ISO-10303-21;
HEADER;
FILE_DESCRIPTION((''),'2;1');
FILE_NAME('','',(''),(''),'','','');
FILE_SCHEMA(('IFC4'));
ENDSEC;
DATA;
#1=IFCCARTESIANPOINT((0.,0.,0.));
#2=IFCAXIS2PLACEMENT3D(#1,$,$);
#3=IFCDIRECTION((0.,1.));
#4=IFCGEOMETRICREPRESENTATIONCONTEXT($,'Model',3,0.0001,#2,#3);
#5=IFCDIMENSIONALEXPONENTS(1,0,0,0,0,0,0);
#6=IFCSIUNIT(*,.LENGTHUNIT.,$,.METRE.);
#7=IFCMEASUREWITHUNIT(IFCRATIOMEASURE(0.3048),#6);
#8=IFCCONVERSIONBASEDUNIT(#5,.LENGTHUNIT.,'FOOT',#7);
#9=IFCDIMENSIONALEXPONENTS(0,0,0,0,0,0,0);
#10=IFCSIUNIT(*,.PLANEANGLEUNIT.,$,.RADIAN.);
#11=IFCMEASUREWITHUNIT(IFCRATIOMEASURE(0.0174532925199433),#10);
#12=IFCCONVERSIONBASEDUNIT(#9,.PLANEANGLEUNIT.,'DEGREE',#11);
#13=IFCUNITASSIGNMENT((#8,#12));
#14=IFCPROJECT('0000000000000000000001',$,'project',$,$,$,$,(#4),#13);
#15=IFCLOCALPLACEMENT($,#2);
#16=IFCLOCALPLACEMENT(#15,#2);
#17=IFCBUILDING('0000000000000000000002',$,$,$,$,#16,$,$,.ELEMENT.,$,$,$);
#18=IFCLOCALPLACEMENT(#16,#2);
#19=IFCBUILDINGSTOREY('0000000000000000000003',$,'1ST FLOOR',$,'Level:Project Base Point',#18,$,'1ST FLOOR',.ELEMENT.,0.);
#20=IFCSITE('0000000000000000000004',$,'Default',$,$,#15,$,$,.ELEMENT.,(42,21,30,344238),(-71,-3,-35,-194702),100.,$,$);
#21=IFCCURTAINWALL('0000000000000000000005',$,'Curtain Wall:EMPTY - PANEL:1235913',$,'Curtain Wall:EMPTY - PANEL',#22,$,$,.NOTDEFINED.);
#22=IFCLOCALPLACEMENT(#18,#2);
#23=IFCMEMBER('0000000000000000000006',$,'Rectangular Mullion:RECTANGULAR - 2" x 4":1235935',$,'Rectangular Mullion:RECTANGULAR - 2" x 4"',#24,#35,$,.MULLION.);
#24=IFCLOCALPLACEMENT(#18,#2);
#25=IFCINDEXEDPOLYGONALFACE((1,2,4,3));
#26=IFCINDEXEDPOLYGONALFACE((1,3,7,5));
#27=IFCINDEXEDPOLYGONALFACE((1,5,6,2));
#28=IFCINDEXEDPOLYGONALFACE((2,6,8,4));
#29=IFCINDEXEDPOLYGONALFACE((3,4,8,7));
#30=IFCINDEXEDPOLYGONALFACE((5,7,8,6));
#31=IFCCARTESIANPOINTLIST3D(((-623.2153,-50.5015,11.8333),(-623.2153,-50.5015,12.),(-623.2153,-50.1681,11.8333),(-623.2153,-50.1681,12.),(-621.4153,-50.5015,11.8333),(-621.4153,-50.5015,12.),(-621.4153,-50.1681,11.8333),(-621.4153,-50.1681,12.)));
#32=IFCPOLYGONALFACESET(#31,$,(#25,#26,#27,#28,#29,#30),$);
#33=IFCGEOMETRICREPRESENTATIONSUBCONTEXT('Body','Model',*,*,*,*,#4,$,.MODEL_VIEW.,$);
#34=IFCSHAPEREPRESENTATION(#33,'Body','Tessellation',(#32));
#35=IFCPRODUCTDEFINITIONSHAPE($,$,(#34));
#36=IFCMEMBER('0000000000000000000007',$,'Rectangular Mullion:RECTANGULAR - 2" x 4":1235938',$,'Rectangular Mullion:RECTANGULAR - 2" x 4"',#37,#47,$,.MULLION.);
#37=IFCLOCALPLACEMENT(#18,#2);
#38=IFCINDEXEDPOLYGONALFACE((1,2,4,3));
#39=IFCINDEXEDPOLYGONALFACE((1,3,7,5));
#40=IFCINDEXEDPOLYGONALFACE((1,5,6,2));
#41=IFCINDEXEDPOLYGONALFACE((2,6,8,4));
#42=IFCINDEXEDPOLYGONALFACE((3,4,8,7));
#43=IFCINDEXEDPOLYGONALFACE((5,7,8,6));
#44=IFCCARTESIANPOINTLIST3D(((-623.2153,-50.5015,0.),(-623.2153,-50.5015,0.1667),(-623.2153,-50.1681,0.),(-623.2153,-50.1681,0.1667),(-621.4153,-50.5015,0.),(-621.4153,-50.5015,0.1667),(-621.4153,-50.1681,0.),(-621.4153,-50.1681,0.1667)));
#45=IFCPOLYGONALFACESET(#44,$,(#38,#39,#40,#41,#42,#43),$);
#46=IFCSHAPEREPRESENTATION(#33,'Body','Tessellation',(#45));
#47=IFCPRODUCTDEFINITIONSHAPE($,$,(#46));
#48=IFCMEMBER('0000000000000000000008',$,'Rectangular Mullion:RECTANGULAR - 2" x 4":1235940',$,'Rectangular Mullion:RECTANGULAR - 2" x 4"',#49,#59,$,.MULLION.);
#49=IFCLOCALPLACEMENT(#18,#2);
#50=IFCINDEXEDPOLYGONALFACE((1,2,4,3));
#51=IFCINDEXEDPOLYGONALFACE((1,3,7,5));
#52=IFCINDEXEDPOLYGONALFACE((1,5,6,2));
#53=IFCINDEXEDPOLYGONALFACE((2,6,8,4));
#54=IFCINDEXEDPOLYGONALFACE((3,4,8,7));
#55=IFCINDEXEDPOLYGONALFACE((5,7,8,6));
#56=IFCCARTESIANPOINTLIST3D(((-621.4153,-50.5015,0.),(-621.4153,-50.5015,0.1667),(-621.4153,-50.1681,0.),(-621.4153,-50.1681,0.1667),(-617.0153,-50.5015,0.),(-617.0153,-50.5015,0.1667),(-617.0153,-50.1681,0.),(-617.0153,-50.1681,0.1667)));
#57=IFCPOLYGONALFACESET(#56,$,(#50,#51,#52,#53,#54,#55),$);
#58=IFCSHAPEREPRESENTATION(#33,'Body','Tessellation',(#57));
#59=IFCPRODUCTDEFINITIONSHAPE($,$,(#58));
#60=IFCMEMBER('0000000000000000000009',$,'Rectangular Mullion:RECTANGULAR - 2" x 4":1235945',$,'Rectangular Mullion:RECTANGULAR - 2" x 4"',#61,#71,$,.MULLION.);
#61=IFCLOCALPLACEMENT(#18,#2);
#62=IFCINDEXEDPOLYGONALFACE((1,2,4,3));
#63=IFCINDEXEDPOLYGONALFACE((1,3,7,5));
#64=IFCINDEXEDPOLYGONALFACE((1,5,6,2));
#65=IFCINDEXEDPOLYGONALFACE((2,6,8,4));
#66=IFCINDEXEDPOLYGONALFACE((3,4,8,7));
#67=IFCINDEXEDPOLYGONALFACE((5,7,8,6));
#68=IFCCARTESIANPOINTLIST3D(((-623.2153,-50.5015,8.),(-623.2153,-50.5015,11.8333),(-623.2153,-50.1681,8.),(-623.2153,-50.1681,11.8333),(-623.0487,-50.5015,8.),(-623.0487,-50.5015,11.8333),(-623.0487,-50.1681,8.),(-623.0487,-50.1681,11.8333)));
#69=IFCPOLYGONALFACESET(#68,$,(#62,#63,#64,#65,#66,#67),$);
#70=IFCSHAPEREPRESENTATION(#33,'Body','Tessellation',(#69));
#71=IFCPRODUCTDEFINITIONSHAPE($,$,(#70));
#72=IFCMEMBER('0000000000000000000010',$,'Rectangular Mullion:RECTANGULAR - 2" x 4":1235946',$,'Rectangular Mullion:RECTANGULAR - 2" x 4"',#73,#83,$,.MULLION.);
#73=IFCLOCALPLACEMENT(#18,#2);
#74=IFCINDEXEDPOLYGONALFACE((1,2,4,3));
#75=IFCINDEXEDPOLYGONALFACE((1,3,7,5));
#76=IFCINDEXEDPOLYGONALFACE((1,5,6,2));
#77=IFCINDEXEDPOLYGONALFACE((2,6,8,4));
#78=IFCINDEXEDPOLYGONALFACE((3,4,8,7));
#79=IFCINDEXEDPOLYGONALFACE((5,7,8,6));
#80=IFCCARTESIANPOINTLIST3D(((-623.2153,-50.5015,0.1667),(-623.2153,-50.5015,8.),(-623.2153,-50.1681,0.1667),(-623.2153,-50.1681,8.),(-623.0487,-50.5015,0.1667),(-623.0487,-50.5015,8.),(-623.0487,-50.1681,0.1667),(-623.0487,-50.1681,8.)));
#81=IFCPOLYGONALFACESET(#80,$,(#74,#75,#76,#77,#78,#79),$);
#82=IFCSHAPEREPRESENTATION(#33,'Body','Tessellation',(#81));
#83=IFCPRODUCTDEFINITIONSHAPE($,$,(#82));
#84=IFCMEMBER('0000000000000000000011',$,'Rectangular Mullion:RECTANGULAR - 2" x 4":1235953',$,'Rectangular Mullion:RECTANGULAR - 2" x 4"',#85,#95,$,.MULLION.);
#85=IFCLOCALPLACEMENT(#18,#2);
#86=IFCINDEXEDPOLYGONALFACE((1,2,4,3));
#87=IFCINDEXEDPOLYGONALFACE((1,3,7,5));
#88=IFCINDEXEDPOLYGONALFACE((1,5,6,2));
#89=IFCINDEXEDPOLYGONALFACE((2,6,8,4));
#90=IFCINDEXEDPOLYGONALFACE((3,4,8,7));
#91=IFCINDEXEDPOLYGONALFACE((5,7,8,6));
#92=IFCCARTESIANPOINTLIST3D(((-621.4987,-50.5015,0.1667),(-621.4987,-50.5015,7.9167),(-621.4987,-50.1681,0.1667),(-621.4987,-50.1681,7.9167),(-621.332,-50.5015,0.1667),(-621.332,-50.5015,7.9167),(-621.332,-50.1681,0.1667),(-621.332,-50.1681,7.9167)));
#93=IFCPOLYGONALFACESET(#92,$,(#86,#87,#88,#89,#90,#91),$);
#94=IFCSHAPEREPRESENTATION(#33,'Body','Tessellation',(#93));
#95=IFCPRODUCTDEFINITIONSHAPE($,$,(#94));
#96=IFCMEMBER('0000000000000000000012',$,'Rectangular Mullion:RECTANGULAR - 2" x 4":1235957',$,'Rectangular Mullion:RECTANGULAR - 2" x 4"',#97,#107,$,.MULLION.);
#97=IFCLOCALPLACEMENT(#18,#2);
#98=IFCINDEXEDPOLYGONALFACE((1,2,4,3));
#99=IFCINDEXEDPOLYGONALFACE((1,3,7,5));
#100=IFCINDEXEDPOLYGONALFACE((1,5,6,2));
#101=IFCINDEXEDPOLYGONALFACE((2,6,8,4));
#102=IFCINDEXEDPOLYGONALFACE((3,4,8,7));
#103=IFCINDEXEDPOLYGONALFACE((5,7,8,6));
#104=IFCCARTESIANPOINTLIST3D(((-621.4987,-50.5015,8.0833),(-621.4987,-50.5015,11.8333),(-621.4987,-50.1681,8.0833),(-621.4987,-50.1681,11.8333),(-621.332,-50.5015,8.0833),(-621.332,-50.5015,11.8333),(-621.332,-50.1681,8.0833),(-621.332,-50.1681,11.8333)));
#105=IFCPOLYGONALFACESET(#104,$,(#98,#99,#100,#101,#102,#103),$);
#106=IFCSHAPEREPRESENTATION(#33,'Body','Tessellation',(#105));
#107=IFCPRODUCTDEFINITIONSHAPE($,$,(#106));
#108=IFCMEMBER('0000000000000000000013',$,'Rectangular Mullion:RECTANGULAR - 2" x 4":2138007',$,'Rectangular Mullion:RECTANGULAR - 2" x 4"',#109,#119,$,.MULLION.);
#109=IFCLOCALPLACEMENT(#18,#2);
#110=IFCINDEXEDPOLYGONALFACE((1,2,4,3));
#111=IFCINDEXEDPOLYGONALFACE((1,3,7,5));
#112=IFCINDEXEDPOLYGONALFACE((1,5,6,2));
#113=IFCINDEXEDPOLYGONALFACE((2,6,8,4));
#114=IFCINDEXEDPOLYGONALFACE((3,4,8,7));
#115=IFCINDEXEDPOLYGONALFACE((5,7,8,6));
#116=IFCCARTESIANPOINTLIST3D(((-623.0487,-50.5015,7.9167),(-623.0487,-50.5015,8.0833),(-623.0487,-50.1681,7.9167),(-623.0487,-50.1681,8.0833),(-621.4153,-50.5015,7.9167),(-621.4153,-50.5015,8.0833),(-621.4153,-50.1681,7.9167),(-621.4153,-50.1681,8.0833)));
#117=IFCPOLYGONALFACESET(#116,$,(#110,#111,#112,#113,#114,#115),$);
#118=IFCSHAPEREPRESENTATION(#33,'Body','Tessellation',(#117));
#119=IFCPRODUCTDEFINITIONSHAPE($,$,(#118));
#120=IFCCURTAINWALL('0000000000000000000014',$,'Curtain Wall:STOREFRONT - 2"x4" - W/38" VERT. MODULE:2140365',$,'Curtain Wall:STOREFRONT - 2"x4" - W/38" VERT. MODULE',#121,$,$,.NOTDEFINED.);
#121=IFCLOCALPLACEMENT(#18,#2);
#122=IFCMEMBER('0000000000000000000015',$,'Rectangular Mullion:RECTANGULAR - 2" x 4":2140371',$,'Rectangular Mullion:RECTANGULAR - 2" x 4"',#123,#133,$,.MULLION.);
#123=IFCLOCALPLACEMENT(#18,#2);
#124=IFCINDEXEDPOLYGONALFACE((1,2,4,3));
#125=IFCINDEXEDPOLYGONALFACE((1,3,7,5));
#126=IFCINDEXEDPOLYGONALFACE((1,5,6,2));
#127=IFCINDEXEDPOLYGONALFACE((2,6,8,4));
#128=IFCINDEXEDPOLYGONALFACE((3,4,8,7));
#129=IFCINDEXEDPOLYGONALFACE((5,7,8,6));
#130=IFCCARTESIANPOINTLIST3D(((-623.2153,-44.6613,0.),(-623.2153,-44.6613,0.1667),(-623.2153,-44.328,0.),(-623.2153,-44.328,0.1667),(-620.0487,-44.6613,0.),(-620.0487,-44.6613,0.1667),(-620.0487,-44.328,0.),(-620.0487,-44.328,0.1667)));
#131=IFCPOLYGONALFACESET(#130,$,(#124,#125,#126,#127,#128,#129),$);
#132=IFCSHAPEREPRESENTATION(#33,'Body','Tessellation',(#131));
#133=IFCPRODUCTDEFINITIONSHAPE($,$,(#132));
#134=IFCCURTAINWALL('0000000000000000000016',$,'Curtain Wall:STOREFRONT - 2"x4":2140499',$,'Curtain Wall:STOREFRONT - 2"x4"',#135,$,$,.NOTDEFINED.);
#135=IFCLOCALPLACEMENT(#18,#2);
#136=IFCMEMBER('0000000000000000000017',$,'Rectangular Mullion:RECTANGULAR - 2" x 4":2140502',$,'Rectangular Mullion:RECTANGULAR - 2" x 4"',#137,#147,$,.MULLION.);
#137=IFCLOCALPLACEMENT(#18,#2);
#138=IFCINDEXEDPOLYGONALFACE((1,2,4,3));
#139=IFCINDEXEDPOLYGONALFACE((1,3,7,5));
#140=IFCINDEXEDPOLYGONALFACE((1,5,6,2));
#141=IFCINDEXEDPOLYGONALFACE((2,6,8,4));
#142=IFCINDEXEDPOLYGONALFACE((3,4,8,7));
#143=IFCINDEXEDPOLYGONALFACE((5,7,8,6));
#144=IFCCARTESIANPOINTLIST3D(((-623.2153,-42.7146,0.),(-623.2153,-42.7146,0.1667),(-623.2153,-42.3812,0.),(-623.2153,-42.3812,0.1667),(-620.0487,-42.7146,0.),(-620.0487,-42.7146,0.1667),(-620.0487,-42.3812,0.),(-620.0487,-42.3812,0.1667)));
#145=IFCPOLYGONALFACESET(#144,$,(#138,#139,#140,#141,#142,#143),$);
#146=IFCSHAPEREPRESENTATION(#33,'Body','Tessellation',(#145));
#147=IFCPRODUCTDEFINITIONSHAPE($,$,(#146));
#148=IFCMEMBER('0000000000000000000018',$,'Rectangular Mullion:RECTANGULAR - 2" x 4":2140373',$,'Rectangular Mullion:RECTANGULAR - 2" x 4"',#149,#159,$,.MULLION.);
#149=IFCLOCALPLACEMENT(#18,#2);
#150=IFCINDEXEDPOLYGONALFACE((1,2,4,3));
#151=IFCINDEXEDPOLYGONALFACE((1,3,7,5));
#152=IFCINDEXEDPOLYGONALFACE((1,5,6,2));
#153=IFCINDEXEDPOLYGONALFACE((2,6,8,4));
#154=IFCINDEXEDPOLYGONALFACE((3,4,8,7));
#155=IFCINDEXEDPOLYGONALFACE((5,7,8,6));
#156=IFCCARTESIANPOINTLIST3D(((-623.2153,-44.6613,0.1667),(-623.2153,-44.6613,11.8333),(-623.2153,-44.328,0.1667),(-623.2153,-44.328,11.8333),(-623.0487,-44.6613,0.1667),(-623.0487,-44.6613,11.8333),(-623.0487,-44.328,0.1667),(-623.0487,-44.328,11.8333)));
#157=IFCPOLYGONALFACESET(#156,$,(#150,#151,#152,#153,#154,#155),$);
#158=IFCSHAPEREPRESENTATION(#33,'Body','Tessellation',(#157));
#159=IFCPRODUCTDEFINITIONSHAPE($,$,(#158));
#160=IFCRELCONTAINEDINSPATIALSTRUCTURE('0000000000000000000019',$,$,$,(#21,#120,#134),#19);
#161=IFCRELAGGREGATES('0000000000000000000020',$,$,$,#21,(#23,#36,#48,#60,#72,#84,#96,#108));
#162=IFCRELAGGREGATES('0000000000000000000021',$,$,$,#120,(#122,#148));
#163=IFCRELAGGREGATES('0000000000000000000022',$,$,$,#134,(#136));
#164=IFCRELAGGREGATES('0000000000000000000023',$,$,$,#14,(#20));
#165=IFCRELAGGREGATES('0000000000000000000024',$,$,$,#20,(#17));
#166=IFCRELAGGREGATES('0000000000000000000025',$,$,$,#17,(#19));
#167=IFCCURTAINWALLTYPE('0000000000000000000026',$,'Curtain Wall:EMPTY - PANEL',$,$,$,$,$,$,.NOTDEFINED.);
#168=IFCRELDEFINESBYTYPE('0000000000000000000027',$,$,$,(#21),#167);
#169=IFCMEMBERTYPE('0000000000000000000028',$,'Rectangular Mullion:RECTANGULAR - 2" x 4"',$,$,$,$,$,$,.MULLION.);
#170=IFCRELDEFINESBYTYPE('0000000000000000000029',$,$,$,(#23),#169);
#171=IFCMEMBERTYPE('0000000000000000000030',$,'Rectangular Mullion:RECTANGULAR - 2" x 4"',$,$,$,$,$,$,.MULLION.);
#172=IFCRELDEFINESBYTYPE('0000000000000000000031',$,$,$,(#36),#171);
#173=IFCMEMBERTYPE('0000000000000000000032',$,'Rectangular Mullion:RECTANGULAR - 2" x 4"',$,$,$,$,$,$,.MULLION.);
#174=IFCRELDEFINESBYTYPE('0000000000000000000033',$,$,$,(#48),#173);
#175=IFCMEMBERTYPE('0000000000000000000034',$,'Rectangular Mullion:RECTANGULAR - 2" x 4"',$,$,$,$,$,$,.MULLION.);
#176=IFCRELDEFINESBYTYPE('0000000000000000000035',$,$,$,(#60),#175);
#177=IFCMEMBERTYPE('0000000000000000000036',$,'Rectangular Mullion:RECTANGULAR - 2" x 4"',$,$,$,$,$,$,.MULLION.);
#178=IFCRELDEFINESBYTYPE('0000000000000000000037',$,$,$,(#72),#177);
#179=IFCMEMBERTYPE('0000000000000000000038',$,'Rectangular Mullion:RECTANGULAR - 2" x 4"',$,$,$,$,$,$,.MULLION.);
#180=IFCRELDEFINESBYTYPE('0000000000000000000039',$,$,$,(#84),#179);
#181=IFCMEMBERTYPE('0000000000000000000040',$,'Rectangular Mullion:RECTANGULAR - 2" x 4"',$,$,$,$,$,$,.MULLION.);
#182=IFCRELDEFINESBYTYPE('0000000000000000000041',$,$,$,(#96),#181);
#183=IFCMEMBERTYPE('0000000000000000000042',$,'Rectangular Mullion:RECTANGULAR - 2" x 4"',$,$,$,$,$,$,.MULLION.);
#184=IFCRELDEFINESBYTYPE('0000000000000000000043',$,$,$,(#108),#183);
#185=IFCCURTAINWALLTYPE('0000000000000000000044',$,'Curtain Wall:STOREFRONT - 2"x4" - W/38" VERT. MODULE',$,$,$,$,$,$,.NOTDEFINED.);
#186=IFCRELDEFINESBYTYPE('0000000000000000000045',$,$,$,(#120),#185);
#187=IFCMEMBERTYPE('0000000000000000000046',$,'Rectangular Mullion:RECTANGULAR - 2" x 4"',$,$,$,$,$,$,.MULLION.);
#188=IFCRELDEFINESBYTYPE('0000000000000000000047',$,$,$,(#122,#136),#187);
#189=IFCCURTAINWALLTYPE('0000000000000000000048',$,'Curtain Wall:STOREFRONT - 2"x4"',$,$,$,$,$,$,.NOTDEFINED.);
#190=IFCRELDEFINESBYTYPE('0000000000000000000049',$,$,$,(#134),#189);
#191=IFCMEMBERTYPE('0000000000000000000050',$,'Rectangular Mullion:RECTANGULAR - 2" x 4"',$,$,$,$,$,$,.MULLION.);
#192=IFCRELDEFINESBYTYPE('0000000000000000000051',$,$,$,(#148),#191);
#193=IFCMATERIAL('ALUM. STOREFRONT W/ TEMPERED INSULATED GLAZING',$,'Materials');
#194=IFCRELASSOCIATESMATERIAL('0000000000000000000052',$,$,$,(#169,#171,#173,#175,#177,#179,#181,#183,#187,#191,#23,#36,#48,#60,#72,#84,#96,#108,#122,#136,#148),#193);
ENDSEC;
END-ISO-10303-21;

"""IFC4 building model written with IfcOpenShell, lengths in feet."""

from ifc_helpers import new_model, entity, si_unit, converted_unit, direction, frame, origin, origin_2d_with_axis, place, context, subcontext, project, spatial, rectangle, extrude, source, transform, mapped, material, material_profile, profile_set, profile_usage, type_object, type_shapes, element, aggregate, save


model = new_model("IFC4")

# Units and contexts
model_context = context("Model", 3, precision=0.0001, world=origin(), true_north=direction((0.0, 1.0)))
body_context = subcontext(model_context, "Body", "Model", "MODEL_VIEW")
ifc_project = project(units=[converted_unit("LENGTHUNIT", "FOOT", entity("IfcRatioMeasure", 0.3048), si_unit("LENGTHUNIT", "METRE"), dimensions=[1, 0, 0, 0, 0, 0, 0]), converted_unit("PLANEANGLEUNIT", "DEGREE", entity("IfcRatioMeasure", 0.0174532925199433), si_unit("PLANEANGLEUNIT", "RADIAN"), dimensions=[0, 0, 0, 0, 0, 0, 0])], contexts=[model_context])

# Site, building, storey
site_placement = place(None, origin())
site = spatial("IfcSite", under=ifc_project, at=site_placement, Name="Default", CompositionType="ELEMENT", RefLatitude=(42, 21, 30, 344238), RefLongitude=(-71, -3, -35, -194702), RefElevation=100.0)
building_placement = place(site_placement, origin())
building = spatial("IfcBuilding", under=site, at=building_placement, CompositionType="ELEMENT")
storey_placement = place(building_placement, origin())
storey = spatial("IfcBuildingStorey", under=building, at=storey_placement, Name="1ST FLOOR", ObjectType="Level:Project Base Point", LongName="1ST FLOOR", CompositionType="ELEMENT", Elevation=0.0)

# Curtain wall, members
curtain_wall_type_1 = type_object("IfcCurtainWallType", Name="Curtain Wall:EMPTY - PANEL", PredefinedType="NOTDEFINED")
curtain_wall_1_placement = place(storey_placement, origin())
curtain_wall_1 = element("IfcCurtainWall", 1, at=curtain_wall_1_placement, inside=storey, type_object=curtain_wall_type_1, Name="Curtain Wall:EMPTY - PANEL:1235913", ObjectType="Curtain Wall:EMPTY - PANEL", PredefinedType="NOTDEFINED")
ifc_material_1 = material(Name="ALUM. STOREFRONT W/ TEMPERED INSULATED GLAZING", Category="Materials")
ifc_material_profile_1 = material_profile(ifc_material_1, rectangle(XDim=0.3333, YDim=0.1667, at=origin_2d_with_axis()), Name="RECTANGULAR - 2\" x 4\"")
ifc_profile_set_1 = profile_set([ifc_material_profile_1], Name="RECTANGULAR - 2\" x 4\"")
ifc_profile_usage_1 = profile_usage(ifc_profile_set_1)
member_type_1 = type_object("IfcMemberType", Name="Rectangular Mullion:RECTANGULAR - 2\" x 4\"", PredefinedType="MULLION", material=ifc_profile_set_1)
shared_shape_1 = source(origin(), body_context, "Body", "SweptSolid", [
    extrude(rectangle(XDim=0.3333, YDim=0.1667, at=origin_2d_with_axis()), frame((-0.0833, 0.0, -1.8), z_axis=(0.0, 0.0, 1.0), x_axis=(0.0, -1.0, 0.0)), (0.0, 0.0, 1.0), 1.8),
])
type_shapes(member_type_1, [shared_shape_1])
member_1_placement = place(storey_placement, frame((-621.4153, -50.3348, 12.0), z_axis=(1.0, 0.0, 0.0), x_axis=(0.0, 0.0, 1.0)))
member_1 = element("IfcMember", 2, at=member_1_placement, type_object=member_type_1, material=ifc_profile_usage_1, Name="Rectangular Mullion:RECTANGULAR - 2\" x 4\":1235935", ObjectType="Rectangular Mullion:RECTANGULAR - 2\" x 4\"", PredefinedType="MULLION", context=body_context, shape_type="MappedRepresentation", body=[
    mapped(shared_shape_1, transform((0.0, 0.0, 0.0), scale=1.0)),
])
ifc_profile_usage_2 = profile_usage(ifc_profile_set_1)
member_type_2 = type_object("IfcMemberType", Name="Rectangular Mullion:RECTANGULAR - 2\" x 4\"", PredefinedType="MULLION", material=ifc_profile_set_1)
shared_shape_2 = source(origin(), body_context, "Body", "SweptSolid", [
    extrude(rectangle(XDim=0.3333, YDim=0.1667, at=origin_2d_with_axis()), frame((-0.0833, 0.0, -1.8), z_axis=(0.0, 0.0, 1.0), x_axis=(0.0, -1.0, 0.0)), (0.0, 0.0, 1.0), 1.8),
])
type_shapes(member_type_2, [shared_shape_2])
member_2_placement = place(storey_placement, frame((-623.2153, -50.3348, 0.0), z_axis=(-1.0, 0.0, 0.0), x_axis=(0.0, 0.0, -1.0)))
member_2 = element("IfcMember", 3, at=member_2_placement, type_object=member_type_2, material=ifc_profile_usage_2, Name="Rectangular Mullion:RECTANGULAR - 2\" x 4\":1235938", ObjectType="Rectangular Mullion:RECTANGULAR - 2\" x 4\"", PredefinedType="MULLION", context=body_context, shape_type="MappedRepresentation", body=[
    mapped(shared_shape_2, transform((0.0, 0.0, 0.0), scale=1.0)),
])
ifc_profile_usage_3 = profile_usage(ifc_profile_set_1)
member_type_3 = type_object("IfcMemberType", Name="Rectangular Mullion:RECTANGULAR - 2\" x 4\"", PredefinedType="MULLION", material=ifc_profile_set_1)
shared_shape_3 = source(origin(), body_context, "Body", "SweptSolid", [
    extrude(rectangle(XDim=0.3333, YDim=0.1667, at=origin_2d_with_axis()), frame((-0.0833, 0.0, -4.4), z_axis=(0.0, 0.0, 1.0), x_axis=(0.0, -1.0, 0.0)), (0.0, 0.0, 1.0), 4.4),
])
type_shapes(member_type_3, [shared_shape_3])
member_3_placement = place(storey_placement, frame((-621.4153, -50.3348, 0.0), z_axis=(-1.0, 0.0, 0.0), x_axis=(0.0, 0.0, -1.0)))
member_3 = element("IfcMember", 4, at=member_3_placement, type_object=member_type_3, material=ifc_profile_usage_3, Name="Rectangular Mullion:RECTANGULAR - 2\" x 4\":1235940", ObjectType="Rectangular Mullion:RECTANGULAR - 2\" x 4\"", PredefinedType="MULLION", context=body_context, shape_type="MappedRepresentation", body=[
    mapped(shared_shape_3, transform((0.0, 0.0, 0.0), scale=1.0)),
])
ifc_profile_usage_4 = profile_usage(ifc_profile_set_1)
member_type_4 = type_object("IfcMemberType", Name="Rectangular Mullion:RECTANGULAR - 2\" x 4\"", PredefinedType="MULLION", material=ifc_profile_set_1)
shared_shape_4 = source(origin(), body_context, "Body", "SweptSolid", [
    extrude(rectangle(XDim=0.3333, YDim=0.1667, at=origin_2d_with_axis()), frame((-0.0833, 0.0, -3.8333), z_axis=(0.0, 0.0, 1.0), x_axis=(0.0, -1.0, 0.0)), (0.0, 0.0, 1.0), 3.8333),
])
type_shapes(member_type_4, [shared_shape_4])
member_4_placement = place(storey_placement, frame((-623.2153, -50.3348, 11.8333), z_axis=(0.0, 0.0, 1.0), x_axis=(-1.0, 0.0, 0.0)))
member_4 = element("IfcMember", 5, at=member_4_placement, type_object=member_type_4, material=ifc_profile_usage_4, Name="Rectangular Mullion:RECTANGULAR - 2\" x 4\":1235945", ObjectType="Rectangular Mullion:RECTANGULAR - 2\" x 4\"", PredefinedType="MULLION", context=body_context, shape_type="MappedRepresentation", body=[
    mapped(shared_shape_4, transform((0.0, 0.0, 0.0), scale=1.0)),
])
ifc_profile_usage_5 = profile_usage(ifc_profile_set_1)
member_type_5 = type_object("IfcMemberType", Name="Rectangular Mullion:RECTANGULAR - 2\" x 4\"", PredefinedType="MULLION", material=ifc_profile_set_1)
shared_shape_5 = source(origin(), body_context, "Body", "SweptSolid", [
    extrude(rectangle(XDim=0.3333, YDim=0.1667, at=origin_2d_with_axis()), frame((-0.0833, 0.0, -7.8333), z_axis=(0.0, 0.0, 1.0), x_axis=(0.0, -1.0, 0.0)), (0.0, 0.0, 1.0), 7.8333),
])
type_shapes(member_type_5, [shared_shape_5])
member_5_placement = place(storey_placement, frame((-623.2153, -50.3348, 8.0), z_axis=(0.0, 0.0, 1.0), x_axis=(-1.0, 0.0, 0.0)))
member_5 = element("IfcMember", 6, at=member_5_placement, type_object=member_type_5, material=ifc_profile_usage_5, Name="Rectangular Mullion:RECTANGULAR - 2\" x 4\":1235946", ObjectType="Rectangular Mullion:RECTANGULAR - 2\" x 4\"", PredefinedType="MULLION", context=body_context, shape_type="MappedRepresentation", body=[
    mapped(shared_shape_5, transform((0.0, 0.0, 0.0), scale=1.0)),
])
ifc_profile_usage_6 = profile_usage(ifc_profile_set_1)
member_type_6 = type_object("IfcMemberType", Name="Rectangular Mullion:RECTANGULAR - 2\" x 4\"", PredefinedType="MULLION", material=ifc_profile_set_1)
shared_shape_6 = source(origin(), body_context, "Body", "SweptSolid", [
    extrude(rectangle(XDim=0.3333, YDim=0.1667, at=origin_2d_with_axis()), frame((0.0, 0.0, -7.75), z_axis=(0.0, 0.0, 1.0), x_axis=(0.0, -1.0, 0.0)), (0.0, 0.0, 1.0), 7.75),
])
type_shapes(member_type_6, [shared_shape_6])
member_6_placement = place(storey_placement, frame((-621.4153, -50.3348, 0.1667), z_axis=(0.0, 0.0, -1.0), x_axis=(1.0, 0.0, 0.0)))
member_6 = element("IfcMember", 7, at=member_6_placement, type_object=member_type_6, material=ifc_profile_usage_6, Name="Rectangular Mullion:RECTANGULAR - 2\" x 4\":1235953", ObjectType="Rectangular Mullion:RECTANGULAR - 2\" x 4\"", PredefinedType="MULLION", context=body_context, shape_type="MappedRepresentation", body=[
    mapped(shared_shape_6, transform((0.0, 0.0, 0.0), scale=1.0)),
])
ifc_profile_usage_7 = profile_usage(ifc_profile_set_1)
member_type_7 = type_object("IfcMemberType", Name="Rectangular Mullion:RECTANGULAR - 2\" x 4\"", PredefinedType="MULLION", material=ifc_profile_set_1)
shared_shape_7 = source(origin(), body_context, "Body", "SweptSolid", [
    extrude(rectangle(XDim=0.3333, YDim=0.1667, at=origin_2d_with_axis()), frame((0.0, 0.0, -3.75), z_axis=(0.0, 0.0, 1.0), x_axis=(0.0, -1.0, 0.0)), (0.0, 0.0, 1.0), 3.75),
])
type_shapes(member_type_7, [shared_shape_7])
member_7_placement = place(storey_placement, frame((-621.4153, -50.3348, 8.0833), z_axis=(0.0, 0.0, -1.0), x_axis=(1.0, 0.0, 0.0)))
member_7 = element("IfcMember", 8, at=member_7_placement, type_object=member_type_7, material=ifc_profile_usage_7, Name="Rectangular Mullion:RECTANGULAR - 2\" x 4\":1235957", ObjectType="Rectangular Mullion:RECTANGULAR - 2\" x 4\"", PredefinedType="MULLION", context=body_context, shape_type="MappedRepresentation", body=[
    mapped(shared_shape_7, transform((0.0, 0.0, 0.0), scale=1.0)),
])
ifc_profile_usage_8 = profile_usage(ifc_profile_set_1)
member_type_8 = type_object("IfcMemberType", Name="Rectangular Mullion:RECTANGULAR - 2\" x 4\"", PredefinedType="MULLION", material=ifc_profile_set_1)
shared_shape_8 = source(origin(), body_context, "Body", "SweptSolid", [
    extrude(rectangle(XDim=0.3333, YDim=0.1667, at=origin_2d_with_axis()), frame((0.0, 0.0, -1.6333), z_axis=(0.0, 0.0, 1.0), x_axis=(0.0, -1.0, 0.0)), (0.0, 0.0, 1.0), 1.6333),
])
type_shapes(member_type_8, [shared_shape_8])
member_8_placement = place(storey_placement, frame((-621.4153, -50.3348, 8.0), z_axis=(1.0, 0.0, 0.0), x_axis=(0.0, 0.0, 1.0)))
member_8 = element("IfcMember", 9, at=member_8_placement, type_object=member_type_8, material=ifc_profile_usage_8, Name="Rectangular Mullion:RECTANGULAR - 2\" x 4\":2138007", ObjectType="Rectangular Mullion:RECTANGULAR - 2\" x 4\"", PredefinedType="MULLION", context=body_context, shape_type="MappedRepresentation", body=[
    mapped(shared_shape_8, transform((0.0, 0.0, 0.0), scale=1.0)),
])
aggregate(curtain_wall_1, [member_1, member_2, member_3, member_4, member_5, member_6, member_7, member_8])

# Curtain walls, members
curtain_wall_type_2 = type_object("IfcCurtainWallType", Name="Curtain Wall:STOREFRONT - 2\"x4\" - W/38\" VERT. MODULE", PredefinedType="NOTDEFINED")
curtain_wall_2_placement = place(storey_placement, origin())
curtain_wall_2 = element("IfcCurtainWall", 10, at=curtain_wall_2_placement, inside=storey, type_object=curtain_wall_type_2, Name="Curtain Wall:STOREFRONT - 2\"x4\" - W/38\" VERT. MODULE:2140365", ObjectType="Curtain Wall:STOREFRONT - 2\"x4\" - W/38\" VERT. MODULE", PredefinedType="NOTDEFINED")
ifc_profile_usage_9 = profile_usage(ifc_profile_set_1)
member_type_9 = type_object("IfcMemberType", Name="Rectangular Mullion:RECTANGULAR - 2\" x 4\"", PredefinedType="MULLION", material=ifc_profile_set_1)
shared_shape_9 = source(origin(), body_context, "Body", "SweptSolid", [
    extrude(rectangle(XDim=0.3333, YDim=0.1667, at=origin_2d_with_axis()), frame((-0.0833, 0.0, -3.1667), z_axis=(0.0, 0.0, 1.0), x_axis=(0.0, -1.0, 0.0)), (0.0, 0.0, 1.0), 3.1667),
])
type_shapes(member_type_9, [shared_shape_9])
member_9_placement = place(storey_placement, frame((-623.2153, -44.4946, 0.0), z_axis=(-1.0, 0.0, 0.0), x_axis=(0.0, 0.0, -1.0)))
member_9 = element("IfcMember", 11, at=member_9_placement, type_object=member_type_9, material=ifc_profile_usage_9, Name="Rectangular Mullion:RECTANGULAR - 2\" x 4\":2140371", ObjectType="Rectangular Mullion:RECTANGULAR - 2\" x 4\"", PredefinedType="MULLION", context=body_context, shape_type="MappedRepresentation", body=[
    mapped(shared_shape_9, transform((0.0, 0.0, 0.0), scale=1.0)),
])
curtain_wall_type_3 = type_object("IfcCurtainWallType", Name="Curtain Wall:STOREFRONT - 2\"x4\"", PredefinedType="NOTDEFINED")
curtain_wall_3_placement = place(storey_placement, origin())
curtain_wall_3 = element("IfcCurtainWall", 12, at=curtain_wall_3_placement, inside=storey, type_object=curtain_wall_type_3, Name="Curtain Wall:STOREFRONT - 2\"x4\":2140499", ObjectType="Curtain Wall:STOREFRONT - 2\"x4\"", PredefinedType="NOTDEFINED")
ifc_profile_usage_10 = profile_usage(ifc_profile_set_1)
member_10_placement = place(storey_placement, frame((-623.2153, -42.5479, 0.0), z_axis=(-1.0, 0.0, 0.0), x_axis=(0.0, 0.0, -1.0)))
member_10 = element("IfcMember", 13, at=member_10_placement, type_object=member_type_9, material=ifc_profile_usage_10, Name="Rectangular Mullion:RECTANGULAR - 2\" x 4\":2140502", ObjectType="Rectangular Mullion:RECTANGULAR - 2\" x 4\"", PredefinedType="MULLION", context=body_context, shape_type="MappedRepresentation", body=[
    mapped(shared_shape_9, transform((0.0, 0.0, 0.0), scale=1.0)),
])

# Member
ifc_profile_usage_11 = profile_usage(ifc_profile_set_1)
member_type_10 = type_object("IfcMemberType", Name="Rectangular Mullion:RECTANGULAR - 2\" x 4\"", PredefinedType="MULLION", material=ifc_profile_set_1)
shared_shape_10 = source(origin(), body_context, "Body", "SweptSolid", [
    extrude(rectangle(XDim=0.3333, YDim=0.1667, at=origin_2d_with_axis()), frame((-0.0833, 0.0, -11.6667), z_axis=(0.0, 0.0, 1.0), x_axis=(0.0, -1.0, 0.0)), (0.0, 0.0, 1.0), 11.6667),
])
type_shapes(member_type_10, [shared_shape_10])
member_11_placement = place(storey_placement, frame((-623.2153, -44.4946, 11.8333), z_axis=(0.0, 0.0, 1.0), x_axis=(-1.0, 0.0, 0.0)))
member_11 = element("IfcMember", 14, at=member_11_placement, type_object=member_type_10, material=ifc_profile_usage_11, Name="Rectangular Mullion:RECTANGULAR - 2\" x 4\":2140373", ObjectType="Rectangular Mullion:RECTANGULAR - 2\" x 4\"", PredefinedType="MULLION", context=body_context, shape_type="MappedRepresentation", body=[
    mapped(shared_shape_10, transform((0.0, 0.0, 0.0), scale=1.0)),
])

aggregate(curtain_wall_2, [member_9, member_11])
aggregate(curtain_wall_3, [member_10])

save(model, "model.ifc")
